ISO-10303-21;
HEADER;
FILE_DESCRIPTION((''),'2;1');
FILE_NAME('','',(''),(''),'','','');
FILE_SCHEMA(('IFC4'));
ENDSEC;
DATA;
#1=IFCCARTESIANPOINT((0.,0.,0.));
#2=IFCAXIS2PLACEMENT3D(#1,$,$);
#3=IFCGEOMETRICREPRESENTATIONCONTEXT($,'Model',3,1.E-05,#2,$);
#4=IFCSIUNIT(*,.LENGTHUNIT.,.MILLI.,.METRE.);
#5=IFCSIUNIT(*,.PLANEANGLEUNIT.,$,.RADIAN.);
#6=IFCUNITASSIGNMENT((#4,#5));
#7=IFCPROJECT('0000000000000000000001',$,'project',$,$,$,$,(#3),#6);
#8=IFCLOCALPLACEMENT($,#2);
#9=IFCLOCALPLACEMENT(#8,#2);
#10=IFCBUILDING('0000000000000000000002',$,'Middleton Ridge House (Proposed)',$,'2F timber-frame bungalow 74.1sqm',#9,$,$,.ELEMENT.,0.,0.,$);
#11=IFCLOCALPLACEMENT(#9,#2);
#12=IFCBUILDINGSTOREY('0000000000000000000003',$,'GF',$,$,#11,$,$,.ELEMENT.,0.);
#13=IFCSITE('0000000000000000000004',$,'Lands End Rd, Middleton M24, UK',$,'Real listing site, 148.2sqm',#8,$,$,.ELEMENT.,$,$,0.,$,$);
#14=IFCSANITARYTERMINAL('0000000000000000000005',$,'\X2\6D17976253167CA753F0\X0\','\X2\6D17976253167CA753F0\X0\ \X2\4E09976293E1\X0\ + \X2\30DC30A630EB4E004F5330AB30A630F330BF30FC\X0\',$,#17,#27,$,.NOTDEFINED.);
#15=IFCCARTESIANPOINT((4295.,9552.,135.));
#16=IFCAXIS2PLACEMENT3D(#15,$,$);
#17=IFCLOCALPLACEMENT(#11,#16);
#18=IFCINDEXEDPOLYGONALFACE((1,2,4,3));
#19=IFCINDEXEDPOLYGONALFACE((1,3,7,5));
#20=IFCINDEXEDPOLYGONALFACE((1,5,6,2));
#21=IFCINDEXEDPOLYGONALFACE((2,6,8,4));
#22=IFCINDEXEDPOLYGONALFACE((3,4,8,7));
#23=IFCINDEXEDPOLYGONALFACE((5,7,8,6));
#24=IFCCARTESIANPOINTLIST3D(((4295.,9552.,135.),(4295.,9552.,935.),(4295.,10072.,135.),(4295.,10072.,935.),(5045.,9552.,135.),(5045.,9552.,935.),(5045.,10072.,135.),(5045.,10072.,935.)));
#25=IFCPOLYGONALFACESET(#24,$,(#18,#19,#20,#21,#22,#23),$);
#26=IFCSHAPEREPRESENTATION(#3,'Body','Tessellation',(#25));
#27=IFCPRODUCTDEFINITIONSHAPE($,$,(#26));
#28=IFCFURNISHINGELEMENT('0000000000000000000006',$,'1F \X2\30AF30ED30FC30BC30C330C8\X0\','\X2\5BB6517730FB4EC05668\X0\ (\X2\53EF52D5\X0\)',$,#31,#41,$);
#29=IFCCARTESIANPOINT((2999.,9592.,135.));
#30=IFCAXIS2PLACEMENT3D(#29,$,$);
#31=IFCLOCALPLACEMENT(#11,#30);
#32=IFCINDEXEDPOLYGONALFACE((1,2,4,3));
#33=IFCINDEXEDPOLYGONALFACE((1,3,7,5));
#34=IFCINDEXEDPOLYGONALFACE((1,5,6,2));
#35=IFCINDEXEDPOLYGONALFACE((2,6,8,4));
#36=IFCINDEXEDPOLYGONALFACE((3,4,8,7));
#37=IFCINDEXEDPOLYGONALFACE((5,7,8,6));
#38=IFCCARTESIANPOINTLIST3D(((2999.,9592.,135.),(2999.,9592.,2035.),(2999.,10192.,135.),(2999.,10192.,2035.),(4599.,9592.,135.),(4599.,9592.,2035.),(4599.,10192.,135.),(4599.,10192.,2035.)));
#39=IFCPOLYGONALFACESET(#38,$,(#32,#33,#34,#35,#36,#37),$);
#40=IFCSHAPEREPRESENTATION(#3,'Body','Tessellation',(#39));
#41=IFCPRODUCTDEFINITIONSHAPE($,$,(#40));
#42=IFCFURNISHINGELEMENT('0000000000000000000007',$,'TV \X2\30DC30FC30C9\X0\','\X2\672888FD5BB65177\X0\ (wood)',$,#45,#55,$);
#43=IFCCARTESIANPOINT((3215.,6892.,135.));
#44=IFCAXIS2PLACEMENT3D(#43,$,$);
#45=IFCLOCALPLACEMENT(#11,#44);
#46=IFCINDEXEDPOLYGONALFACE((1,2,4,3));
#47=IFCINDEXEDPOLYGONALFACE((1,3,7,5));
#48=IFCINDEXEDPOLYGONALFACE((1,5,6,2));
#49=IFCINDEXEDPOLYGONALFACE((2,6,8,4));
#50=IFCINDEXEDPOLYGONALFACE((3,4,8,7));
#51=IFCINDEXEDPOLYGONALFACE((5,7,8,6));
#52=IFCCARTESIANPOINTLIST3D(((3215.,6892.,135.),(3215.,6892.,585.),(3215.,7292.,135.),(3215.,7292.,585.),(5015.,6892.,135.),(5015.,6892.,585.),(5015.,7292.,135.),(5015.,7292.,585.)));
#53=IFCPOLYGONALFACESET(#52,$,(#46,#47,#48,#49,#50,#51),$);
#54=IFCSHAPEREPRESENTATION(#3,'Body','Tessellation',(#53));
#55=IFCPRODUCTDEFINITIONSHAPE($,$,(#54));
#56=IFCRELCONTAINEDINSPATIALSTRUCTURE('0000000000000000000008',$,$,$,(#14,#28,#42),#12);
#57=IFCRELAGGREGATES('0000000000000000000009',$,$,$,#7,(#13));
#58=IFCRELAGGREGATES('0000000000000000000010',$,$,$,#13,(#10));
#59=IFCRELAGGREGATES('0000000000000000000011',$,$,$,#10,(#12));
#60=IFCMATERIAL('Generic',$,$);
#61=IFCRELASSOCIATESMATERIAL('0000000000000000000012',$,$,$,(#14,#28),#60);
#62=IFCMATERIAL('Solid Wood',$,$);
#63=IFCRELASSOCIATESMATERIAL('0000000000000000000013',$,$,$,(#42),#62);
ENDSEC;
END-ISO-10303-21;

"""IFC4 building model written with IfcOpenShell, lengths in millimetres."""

from ifc_helpers import new_model, si_unit, frame, frame_2d, origin, place, context, project, spatial, rectangle, extrude, material, element, save


model = new_model("IFC4")

# Units and contexts
model_context = context("Model", 3, precision=1e-05, world=origin())
ifc_project = project(units=[si_unit("LENGTHUNIT", "METRE", prefix="MILLI"), si_unit("PLANEANGLEUNIT", "RADIAN")], contexts=[model_context])

# Site, building, storey
site_placement = place(None, origin())
site = spatial("IfcSite", under=ifc_project, at=site_placement, Name="Lands End Rd, Middleton M24, UK", ObjectType="Real listing site, 148.2sqm", CompositionType="ELEMENT", RefElevation=0.0)
building_placement = place(site_placement, origin())
building = spatial("IfcBuilding", under=site, at=building_placement, Name="Middleton Ridge House (Proposed)", ObjectType="2F timber-frame bungalow 74.1sqm", CompositionType="ELEMENT", ElevationOfRefHeight=0.0, ElevationOfTerrain=0.0)
storey_placement = place(building_placement, origin())
storey = spatial("IfcBuildingStorey", under=building, at=storey_placement, Name="GF", CompositionType="ELEMENT", Elevation=0.0)

# Shared definitions
ifc_material_1 = material(Name="Solid Wood")

# Shared definitions
ifc_material_2 = material(Name="Generic")

# Sanitary terminal
sanitary_terminal_1_placement = place(storey_placement, frame((4295.0, 9552.0, 135.0)))
element("IfcSanitaryTerminal", 1, at=sanitary_terminal_1_placement, inside=storey, material=ifc_material_2, Name="洗面化粧台", Description="洗面化粧台 三面鏡 + ボウル一体カウンター", PredefinedType="NOTDEFINED", context=model_context, shape_type="SweptSolid", body=[
    extrude(rectangle(XDim=750.0, YDim=520.0, at=frame_2d((375.0, 260.0))), frame((4295.0, 9552.0, 135.0)), (0.0, 0.0, 1.0), 800.0),
])

# Furnishing elements
furnishing_1_placement = place(storey_placement, frame((2999.0, 9592.0, 135.0)))
element("IfcFurnishingElement", 2, at=furnishing_1_placement, inside=storey, material=ifc_material_2, Name="1F クローゼット", Description="家具・什器 (可動)", context=model_context, shape_type="SweptSolid", body=[
    extrude(rectangle(XDim=1600.0, YDim=600.0, at=frame_2d((800.0, 300.0))), frame((2999.0, 9592.0, 135.0)), (0.0, 0.0, 1.0), 1900.0),
])
furnishing_2_placement = place(storey_placement, frame((3215.0, 6892.0, 135.0)))
element("IfcFurnishingElement", 3, at=furnishing_2_placement, inside=storey, material=ifc_material_1, Name="TV ボード", Description="木製家具 (wood)", context=model_context, shape_type="SweptSolid", body=[
    extrude(rectangle(XDim=1800.0, YDim=400.0, at=frame_2d((900.0, 200.0))), frame((3215.0, 6892.0, 135.0)), (0.0, 0.0, 1.0), 450.0),
])

save(model, "model.ifc")
